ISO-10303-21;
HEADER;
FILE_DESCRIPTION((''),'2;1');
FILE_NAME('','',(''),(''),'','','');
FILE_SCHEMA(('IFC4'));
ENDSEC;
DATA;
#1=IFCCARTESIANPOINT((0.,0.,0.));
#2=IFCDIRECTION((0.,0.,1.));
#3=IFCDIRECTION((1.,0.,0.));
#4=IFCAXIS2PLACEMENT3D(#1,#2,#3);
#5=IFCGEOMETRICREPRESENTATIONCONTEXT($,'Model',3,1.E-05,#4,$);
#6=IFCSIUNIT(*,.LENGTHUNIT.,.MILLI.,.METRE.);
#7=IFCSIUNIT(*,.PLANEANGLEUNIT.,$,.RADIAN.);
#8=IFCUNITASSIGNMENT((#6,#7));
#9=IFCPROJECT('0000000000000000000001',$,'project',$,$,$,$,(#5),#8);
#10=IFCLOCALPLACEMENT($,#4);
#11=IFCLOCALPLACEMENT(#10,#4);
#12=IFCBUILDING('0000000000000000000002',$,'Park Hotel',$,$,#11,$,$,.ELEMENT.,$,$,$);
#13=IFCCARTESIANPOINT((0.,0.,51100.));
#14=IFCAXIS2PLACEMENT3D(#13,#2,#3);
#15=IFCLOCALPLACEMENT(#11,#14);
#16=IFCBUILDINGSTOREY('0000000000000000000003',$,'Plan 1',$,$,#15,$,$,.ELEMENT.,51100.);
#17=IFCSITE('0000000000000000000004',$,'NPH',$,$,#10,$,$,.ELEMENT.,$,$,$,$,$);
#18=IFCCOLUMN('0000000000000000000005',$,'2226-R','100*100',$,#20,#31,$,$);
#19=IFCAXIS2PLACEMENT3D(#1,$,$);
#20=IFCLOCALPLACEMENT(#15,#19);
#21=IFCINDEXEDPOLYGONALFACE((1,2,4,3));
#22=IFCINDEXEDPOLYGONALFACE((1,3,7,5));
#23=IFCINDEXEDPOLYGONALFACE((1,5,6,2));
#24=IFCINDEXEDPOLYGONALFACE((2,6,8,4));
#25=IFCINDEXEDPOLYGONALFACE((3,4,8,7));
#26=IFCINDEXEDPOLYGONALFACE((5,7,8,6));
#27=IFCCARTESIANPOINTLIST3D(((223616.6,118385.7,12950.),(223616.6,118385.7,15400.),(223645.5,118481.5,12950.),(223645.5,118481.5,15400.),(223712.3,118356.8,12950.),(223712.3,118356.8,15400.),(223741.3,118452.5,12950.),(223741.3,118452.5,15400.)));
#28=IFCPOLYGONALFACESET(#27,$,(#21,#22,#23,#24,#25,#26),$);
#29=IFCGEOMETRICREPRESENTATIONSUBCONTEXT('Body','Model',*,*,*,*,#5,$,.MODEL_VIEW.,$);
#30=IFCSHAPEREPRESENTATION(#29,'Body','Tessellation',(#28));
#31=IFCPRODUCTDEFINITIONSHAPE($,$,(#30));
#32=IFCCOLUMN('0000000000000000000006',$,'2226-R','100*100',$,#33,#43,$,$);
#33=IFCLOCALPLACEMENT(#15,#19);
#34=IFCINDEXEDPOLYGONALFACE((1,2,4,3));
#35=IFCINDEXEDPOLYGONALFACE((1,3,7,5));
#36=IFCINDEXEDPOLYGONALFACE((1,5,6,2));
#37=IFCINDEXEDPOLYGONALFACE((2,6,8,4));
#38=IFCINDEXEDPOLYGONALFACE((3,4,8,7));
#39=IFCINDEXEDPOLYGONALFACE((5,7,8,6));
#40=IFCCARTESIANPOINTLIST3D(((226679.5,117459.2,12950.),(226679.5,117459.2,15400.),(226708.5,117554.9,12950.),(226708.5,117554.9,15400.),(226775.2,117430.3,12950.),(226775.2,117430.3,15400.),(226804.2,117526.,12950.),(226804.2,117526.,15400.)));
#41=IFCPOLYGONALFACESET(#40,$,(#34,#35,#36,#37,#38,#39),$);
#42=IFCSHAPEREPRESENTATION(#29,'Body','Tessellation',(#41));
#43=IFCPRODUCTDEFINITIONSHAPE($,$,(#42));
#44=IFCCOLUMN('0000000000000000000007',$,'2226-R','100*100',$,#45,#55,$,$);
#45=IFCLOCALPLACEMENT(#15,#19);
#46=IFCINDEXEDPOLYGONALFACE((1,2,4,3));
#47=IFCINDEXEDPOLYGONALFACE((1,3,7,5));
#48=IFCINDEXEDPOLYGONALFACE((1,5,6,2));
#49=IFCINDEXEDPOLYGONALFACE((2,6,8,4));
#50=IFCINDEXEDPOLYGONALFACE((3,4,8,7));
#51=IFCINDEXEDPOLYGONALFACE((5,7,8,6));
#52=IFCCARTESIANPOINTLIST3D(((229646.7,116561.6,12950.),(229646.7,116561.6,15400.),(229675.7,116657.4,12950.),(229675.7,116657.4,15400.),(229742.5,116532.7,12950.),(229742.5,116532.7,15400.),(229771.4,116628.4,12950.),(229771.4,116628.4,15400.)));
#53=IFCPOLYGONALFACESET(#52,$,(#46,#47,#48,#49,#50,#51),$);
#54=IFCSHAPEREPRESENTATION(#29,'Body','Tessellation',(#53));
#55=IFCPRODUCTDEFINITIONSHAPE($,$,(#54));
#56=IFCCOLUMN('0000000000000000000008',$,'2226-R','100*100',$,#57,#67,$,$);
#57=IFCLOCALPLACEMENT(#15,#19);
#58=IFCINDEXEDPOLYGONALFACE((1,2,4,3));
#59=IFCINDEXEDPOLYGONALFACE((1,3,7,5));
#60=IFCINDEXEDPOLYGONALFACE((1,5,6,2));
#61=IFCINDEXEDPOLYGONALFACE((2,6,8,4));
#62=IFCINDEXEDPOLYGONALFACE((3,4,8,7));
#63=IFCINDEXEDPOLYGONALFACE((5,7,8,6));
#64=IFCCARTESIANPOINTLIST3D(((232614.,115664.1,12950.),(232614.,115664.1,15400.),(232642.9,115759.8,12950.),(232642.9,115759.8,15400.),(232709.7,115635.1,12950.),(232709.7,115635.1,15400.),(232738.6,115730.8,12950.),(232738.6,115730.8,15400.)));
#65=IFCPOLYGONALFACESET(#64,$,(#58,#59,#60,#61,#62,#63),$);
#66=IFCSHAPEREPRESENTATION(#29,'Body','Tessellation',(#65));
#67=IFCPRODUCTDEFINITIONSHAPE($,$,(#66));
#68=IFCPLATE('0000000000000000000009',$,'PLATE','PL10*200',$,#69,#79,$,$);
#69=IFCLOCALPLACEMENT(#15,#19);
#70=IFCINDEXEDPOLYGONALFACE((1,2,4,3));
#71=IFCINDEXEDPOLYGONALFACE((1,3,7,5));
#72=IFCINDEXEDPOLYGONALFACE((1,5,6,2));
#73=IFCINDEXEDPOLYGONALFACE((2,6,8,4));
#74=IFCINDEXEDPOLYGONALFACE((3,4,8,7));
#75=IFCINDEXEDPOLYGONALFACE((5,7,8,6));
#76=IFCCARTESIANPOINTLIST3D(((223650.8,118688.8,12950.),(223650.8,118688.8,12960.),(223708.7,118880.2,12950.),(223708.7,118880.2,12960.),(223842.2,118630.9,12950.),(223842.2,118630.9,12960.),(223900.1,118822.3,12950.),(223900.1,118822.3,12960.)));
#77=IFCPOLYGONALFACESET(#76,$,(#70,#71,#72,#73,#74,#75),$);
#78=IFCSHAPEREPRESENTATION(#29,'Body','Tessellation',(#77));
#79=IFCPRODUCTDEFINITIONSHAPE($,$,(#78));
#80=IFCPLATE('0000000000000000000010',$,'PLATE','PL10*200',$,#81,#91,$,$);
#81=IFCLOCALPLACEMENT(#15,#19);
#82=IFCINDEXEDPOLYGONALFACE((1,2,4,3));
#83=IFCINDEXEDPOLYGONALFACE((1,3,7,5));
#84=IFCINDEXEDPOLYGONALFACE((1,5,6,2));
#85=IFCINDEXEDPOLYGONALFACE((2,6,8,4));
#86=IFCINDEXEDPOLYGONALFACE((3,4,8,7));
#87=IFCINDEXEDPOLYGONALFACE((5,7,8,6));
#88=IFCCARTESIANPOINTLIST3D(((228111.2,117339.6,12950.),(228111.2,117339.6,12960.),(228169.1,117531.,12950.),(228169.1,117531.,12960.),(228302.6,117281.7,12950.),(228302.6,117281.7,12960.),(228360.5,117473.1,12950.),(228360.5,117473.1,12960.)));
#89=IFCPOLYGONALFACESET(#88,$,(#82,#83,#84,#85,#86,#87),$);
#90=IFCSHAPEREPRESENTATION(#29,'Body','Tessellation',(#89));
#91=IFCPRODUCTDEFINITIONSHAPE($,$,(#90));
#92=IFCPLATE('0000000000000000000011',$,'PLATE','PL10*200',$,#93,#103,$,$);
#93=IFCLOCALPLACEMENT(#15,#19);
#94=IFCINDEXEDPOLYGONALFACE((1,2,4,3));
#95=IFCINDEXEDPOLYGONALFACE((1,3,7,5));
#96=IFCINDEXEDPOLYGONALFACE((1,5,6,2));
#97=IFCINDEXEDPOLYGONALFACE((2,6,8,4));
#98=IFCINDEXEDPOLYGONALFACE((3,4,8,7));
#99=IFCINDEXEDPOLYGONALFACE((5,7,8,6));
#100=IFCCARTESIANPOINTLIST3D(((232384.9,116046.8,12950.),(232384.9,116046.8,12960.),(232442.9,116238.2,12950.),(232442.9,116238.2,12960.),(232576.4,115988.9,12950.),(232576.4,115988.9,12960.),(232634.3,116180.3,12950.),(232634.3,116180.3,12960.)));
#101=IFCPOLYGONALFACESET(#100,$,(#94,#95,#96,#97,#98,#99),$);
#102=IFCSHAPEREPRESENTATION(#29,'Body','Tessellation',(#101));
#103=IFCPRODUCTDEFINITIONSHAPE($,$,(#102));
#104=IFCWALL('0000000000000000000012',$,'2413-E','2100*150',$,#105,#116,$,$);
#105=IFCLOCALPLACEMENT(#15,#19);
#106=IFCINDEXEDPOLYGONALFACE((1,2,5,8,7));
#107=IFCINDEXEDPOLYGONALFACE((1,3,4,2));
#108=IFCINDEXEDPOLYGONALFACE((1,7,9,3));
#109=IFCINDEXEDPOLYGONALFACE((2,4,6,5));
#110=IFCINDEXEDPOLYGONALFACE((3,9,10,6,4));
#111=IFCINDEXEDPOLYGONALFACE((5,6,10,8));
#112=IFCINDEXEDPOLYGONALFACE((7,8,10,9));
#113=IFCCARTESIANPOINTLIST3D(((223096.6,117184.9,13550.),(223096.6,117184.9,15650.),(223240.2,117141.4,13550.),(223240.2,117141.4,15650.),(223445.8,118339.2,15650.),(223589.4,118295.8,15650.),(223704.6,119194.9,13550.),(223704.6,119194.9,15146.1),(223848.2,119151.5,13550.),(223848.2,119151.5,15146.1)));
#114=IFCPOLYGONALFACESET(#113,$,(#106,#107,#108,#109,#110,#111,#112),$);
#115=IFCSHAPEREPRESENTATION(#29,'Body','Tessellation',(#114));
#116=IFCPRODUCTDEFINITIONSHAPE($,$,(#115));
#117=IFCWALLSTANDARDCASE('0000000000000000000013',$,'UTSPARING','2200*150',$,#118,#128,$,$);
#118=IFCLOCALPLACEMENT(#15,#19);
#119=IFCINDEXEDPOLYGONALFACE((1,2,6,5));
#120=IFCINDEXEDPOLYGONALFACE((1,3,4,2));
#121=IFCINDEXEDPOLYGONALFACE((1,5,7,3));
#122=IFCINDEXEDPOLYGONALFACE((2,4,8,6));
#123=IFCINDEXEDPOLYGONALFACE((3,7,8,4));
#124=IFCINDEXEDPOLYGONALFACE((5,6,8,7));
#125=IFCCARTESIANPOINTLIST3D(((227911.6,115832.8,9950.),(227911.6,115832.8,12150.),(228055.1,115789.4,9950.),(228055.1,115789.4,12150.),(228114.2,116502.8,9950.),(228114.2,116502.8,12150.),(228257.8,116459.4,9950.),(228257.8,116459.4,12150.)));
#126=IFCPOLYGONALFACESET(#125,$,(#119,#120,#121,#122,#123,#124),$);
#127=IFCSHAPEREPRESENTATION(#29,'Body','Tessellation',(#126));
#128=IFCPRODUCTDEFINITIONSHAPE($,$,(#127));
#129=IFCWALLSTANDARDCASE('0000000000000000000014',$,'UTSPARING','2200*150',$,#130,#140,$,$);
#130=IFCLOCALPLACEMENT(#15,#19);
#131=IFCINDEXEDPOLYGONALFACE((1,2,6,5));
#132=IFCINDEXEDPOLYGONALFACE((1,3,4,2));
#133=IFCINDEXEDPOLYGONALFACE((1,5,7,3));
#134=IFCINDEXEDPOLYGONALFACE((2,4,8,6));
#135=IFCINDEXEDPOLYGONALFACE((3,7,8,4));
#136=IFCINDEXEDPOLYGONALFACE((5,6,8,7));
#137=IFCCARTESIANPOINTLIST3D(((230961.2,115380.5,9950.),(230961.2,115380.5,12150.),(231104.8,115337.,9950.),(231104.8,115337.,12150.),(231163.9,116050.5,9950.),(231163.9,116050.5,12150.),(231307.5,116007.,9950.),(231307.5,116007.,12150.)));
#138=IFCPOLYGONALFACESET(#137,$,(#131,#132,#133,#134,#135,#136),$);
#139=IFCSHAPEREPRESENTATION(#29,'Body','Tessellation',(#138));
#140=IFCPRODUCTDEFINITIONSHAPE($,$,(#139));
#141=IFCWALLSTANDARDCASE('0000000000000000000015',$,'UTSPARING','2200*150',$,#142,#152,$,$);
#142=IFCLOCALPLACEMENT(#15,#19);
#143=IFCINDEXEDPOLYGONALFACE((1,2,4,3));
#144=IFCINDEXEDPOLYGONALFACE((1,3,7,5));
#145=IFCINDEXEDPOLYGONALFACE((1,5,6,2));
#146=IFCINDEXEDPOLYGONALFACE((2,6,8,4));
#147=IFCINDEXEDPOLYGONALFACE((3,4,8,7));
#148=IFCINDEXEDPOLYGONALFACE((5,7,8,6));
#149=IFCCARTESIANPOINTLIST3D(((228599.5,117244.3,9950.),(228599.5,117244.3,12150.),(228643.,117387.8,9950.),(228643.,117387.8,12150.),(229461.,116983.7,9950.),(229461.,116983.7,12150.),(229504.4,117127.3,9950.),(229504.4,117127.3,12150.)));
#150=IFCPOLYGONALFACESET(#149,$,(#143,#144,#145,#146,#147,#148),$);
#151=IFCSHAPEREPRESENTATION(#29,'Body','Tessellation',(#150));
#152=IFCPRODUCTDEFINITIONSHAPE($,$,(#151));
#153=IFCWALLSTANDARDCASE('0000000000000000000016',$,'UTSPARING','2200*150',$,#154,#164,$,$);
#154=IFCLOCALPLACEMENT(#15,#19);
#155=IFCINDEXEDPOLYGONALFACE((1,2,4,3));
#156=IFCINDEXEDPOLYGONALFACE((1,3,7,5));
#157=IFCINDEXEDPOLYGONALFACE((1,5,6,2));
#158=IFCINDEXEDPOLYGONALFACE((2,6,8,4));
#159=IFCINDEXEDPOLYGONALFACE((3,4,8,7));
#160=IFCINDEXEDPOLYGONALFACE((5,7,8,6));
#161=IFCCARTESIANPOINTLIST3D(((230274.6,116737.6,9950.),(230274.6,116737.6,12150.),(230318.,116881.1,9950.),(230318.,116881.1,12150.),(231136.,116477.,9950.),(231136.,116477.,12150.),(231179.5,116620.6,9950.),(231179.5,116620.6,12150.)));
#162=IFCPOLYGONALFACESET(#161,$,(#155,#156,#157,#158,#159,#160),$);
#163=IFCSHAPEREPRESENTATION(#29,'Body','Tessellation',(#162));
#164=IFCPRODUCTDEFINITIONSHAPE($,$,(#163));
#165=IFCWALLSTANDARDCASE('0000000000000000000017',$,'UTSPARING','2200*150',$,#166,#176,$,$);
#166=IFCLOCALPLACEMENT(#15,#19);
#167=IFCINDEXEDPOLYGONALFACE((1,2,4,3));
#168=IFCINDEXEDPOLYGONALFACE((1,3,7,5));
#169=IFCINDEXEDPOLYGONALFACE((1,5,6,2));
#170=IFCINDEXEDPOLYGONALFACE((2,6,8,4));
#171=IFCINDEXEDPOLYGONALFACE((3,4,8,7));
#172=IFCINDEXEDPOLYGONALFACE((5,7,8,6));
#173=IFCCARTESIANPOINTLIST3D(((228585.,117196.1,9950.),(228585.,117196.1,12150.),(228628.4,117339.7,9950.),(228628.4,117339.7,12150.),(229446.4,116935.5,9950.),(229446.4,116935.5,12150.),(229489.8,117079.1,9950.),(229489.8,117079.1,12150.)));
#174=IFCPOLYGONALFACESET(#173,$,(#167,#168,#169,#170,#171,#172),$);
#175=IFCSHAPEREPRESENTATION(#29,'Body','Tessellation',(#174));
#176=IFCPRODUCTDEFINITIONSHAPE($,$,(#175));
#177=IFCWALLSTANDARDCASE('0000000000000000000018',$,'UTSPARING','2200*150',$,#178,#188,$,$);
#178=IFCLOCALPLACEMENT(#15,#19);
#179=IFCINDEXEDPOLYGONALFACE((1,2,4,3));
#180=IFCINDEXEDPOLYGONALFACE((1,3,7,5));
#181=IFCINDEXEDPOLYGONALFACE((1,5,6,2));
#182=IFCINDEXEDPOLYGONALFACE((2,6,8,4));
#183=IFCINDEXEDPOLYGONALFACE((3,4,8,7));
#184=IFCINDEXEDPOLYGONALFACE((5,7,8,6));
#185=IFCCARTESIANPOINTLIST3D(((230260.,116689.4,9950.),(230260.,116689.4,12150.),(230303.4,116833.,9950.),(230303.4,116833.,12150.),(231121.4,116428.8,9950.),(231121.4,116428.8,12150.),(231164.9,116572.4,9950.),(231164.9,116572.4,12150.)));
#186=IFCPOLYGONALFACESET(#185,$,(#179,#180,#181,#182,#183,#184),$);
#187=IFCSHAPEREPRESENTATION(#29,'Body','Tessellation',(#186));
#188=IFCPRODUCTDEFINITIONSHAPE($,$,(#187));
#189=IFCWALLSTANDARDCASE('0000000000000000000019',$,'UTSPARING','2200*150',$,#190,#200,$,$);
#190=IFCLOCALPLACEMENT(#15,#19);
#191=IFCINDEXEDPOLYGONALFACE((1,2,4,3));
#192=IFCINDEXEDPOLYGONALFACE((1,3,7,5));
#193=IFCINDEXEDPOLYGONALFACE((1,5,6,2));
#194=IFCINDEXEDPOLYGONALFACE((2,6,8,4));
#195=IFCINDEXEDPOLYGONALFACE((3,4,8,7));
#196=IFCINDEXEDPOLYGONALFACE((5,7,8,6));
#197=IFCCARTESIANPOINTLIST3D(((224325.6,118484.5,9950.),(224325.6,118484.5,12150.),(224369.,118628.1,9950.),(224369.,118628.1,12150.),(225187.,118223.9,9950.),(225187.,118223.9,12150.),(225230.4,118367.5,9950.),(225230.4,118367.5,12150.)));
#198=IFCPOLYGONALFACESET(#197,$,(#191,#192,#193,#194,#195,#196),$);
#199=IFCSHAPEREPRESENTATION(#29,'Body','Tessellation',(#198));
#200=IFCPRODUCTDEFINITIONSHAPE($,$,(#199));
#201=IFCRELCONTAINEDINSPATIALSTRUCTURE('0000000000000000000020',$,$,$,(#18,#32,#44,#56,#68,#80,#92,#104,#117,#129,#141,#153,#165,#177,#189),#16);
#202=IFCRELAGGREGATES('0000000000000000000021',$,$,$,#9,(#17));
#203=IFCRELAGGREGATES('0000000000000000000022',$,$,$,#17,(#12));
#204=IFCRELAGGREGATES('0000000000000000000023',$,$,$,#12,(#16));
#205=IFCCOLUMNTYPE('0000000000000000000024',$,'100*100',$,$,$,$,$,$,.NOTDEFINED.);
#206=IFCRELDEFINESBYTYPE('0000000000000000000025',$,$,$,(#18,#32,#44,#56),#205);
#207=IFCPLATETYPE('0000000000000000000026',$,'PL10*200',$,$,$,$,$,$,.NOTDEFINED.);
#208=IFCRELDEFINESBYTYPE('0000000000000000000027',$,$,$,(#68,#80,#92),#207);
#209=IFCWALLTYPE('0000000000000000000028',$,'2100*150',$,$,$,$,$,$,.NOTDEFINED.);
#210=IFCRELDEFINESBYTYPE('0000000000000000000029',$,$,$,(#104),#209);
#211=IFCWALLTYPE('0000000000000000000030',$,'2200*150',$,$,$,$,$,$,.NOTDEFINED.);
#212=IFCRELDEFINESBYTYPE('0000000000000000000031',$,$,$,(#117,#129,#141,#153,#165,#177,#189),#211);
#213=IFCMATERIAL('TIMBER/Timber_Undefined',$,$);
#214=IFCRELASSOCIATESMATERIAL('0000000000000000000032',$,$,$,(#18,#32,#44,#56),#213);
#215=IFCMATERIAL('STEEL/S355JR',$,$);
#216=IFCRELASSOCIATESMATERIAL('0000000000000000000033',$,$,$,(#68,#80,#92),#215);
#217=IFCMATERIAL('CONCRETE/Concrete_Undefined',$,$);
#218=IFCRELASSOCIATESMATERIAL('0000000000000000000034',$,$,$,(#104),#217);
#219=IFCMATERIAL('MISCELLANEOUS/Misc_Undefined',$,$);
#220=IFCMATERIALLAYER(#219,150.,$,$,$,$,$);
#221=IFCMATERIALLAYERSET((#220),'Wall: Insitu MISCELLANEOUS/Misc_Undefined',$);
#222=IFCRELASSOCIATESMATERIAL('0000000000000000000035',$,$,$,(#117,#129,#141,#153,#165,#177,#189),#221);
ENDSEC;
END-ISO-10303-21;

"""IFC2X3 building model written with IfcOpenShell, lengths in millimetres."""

from ifc_helpers import new_model, si_unit, frame, frame_2d, origin_with_axes, origin_2d_with_axis, place, context, subcontext, project, spatial, polyline, rectangle, outline, extrude, clip, halfspace, material, layer, layer_set, layer_usage, type_object, element, save


model = new_model("IFC2X3")

# Units and contexts
model_context = context("Model", 3, precision=1e-05, world=origin_with_axes())
body_context = subcontext(model_context, "Body", "Model", "MODEL_VIEW")
ifc_project = project(units=[si_unit("LENGTHUNIT", "METRE", prefix="MILLI"), si_unit("PLANEANGLEUNIT", "RADIAN")], contexts=[model_context])

# Site, building, storey
site_placement = place(None, origin_with_axes())
site = spatial("IfcSite", under=ifc_project, at=site_placement, Name="NPH", CompositionType="ELEMENT")
building_placement = place(site_placement, origin_with_axes())
building = spatial("IfcBuilding", under=site, at=building_placement, Name="Park Hotel", CompositionType="ELEMENT")
storey_placement = place(building_placement, frame((0.0, 0.0, 51100.0), z_axis=(0.0, 0.0, 1.0), x_axis=(1.0, 0.0, 0.0)))
storey = spatial("IfcBuildingStorey", under=building, at=storey_placement, Name="Plan 1", CompositionType="ELEMENT", Elevation=51100.0)

# Columns
ifc_material_1 = material(Name="TIMBER/Timber_Undefined")
column_type = type_object("IfcColumnType", Name="100*100", PredefinedType="NOTDEFINED")
for number, where, z_axis, x_axis, name in (
    (1, (223678.9, 118419.1, 15400.0), (0.0, 0.0, -1.0), (0.289538, 0.957167, 0.0), "2226-R"),
    (2, (226741.9, 117492.6, 15400.0), (0.0, 0.0, -1.0), (0.289538, 0.957167, 0.0), "2226-R"),
    (3, (229709.1, 116595.0, 15400.0), (0.0, 0.0, -1.0), (0.289538, 0.957167, 0.0), "2226-R"),
    (4, (232676.3, 115697.5, 15400.0), (0.0, 0.0, -1.0), (0.289538, 0.957167, 0.0), "2226-R"),
):
    element("IfcColumn", number, at=place(storey_placement, frame(where, z_axis=z_axis, x_axis=x_axis)), inside=storey, type_object=column_type, material=ifc_material_1, Name=name, Description="100*100", context=body_context, shape_type="SweptSolid", body=[
        extrude(rectangle(XDim=100.0, YDim=100.0, at=origin_2d_with_axis()), frame((0.0, 0.0, 2450.0), z_axis=(0.0, 0.0, -1.0), x_axis=(0.0, 1.0, 0.0)), (0.0, 0.0, 1.0), 2450.0),
    ])

# Plates
ifc_material_2 = material(Name="STEEL/S355JR")
plate_type = type_object("IfcPlateType", Name="PL10*200", PredefinedType="NOTDEFINED")
for number, where, z_axis, x_axis, name in (
    (5, (223871.2, 118726.6, 12955.0), (0.0, 0.0, 1.0), (-0.957167, 0.289538, 0.0), "PLATE"),
    (6, (228331.6, 117377.4, 12955.0), (0.0, 0.0, 1.0), (-0.957167, 0.289538, 0.0), "PLATE"),
    (7, (232605.3, 116084.6, 12955.0), (0.0, 0.0, 1.0), (-0.957167, 0.289538, 0.0), "PLATE"),
):
    element("IfcPlate", number, at=place(storey_placement, frame(where, z_axis=z_axis, x_axis=x_axis)), inside=storey, type_object=plate_type, material=ifc_material_2, Name=name, Description="PL10*200", context=body_context, shape_type="SweptSolid", body=[
        extrude(outline(polyline([(200.0, 100.0), (200.0, -100.0), (0.0, -100.0), (0.0, 100.0), (200.0, 100.0)])), frame((0.0, 0.0, -5.0), z_axis=(0.0, 0.0, 1.0), x_axis=(1.0, 0.0, 0.0)), (0.0, 0.0, 1.0), 10.0),
    ])

# Walls
ifc_material_3 = material(Name="CONCRETE/Concrete_Undefined")
wall_type_1 = type_object("IfcWallType", Name="2100*150", PredefinedType="NOTDEFINED")
wall_1_placement = place(storey_placement, frame((223776.4, 119173.2, 13550.0), z_axis=(0.0, 0.0, 1.0), x_axis=(-0.289536, -0.957167, 0.0)))
element("IfcWall", 8, at=wall_1_placement, inside=storey, type_object=wall_type_1, material=ifc_material_3, Name="2413-E", Description="2100*150", context=body_context, shape_type="Clipping", body=[
    clip(extrude(rectangle(XDim=2100.0, YDim=150.0, at=frame_2d((0.0, 1050.0), x_axis=(0.0, -1.0))), frame((0.0, 0.0, 0.0), z_axis=(0.0, 0.0, 1.0), x_axis=(0.0, -1.0, 0.0)), (0.0, 0.0, 1.0), 2100.0), halfspace(frame((-3896.1, 75.0, -599.9), z_axis=(-0.491013, 0.000001, 0.871152), x_axis=(0.871152, -0.000002, 0.491013)), False)),
])
ifc_material_4 = material(Name="MISCELLANEOUS/Misc_Undefined")
ifc_layer_1 = layer(ifc_material_4, 150.0)
ifc_layer_set_1 = layer_set([ifc_layer_1], Name="Wall: Insitu MISCELLANEOUS/Misc_Undefined")
ifc_layer_usage_1 = layer_usage(ifc_layer_set_1, "AXIS2", "POSITIVE", -75.0)
wall_type_2 = type_object("IfcWallType", Name="2200*150", PredefinedType="NOTDEFINED")
wall_2_placement = place(storey_placement, frame((228186.0, 116481.1, 9950.0), z_axis=(0.0, 0.0, 1.0), x_axis=(-0.289534, -0.957168, 0.0)))
element("IfcWallStandardCase", 9, at=wall_2_placement, inside=storey, type_object=wall_type_2, material=ifc_layer_usage_1, Name="UTSPARING", Description="2200*150", context=body_context, shape_type="SweptSolid", body=[
    extrude(rectangle(XDim=700.0, YDim=150.0, at=frame_2d((0.0, 350.0), x_axis=(0.0, -1.0))), frame((0.0, 0.0, 0.0), z_axis=(0.0, 0.0, 1.0), x_axis=(0.0, -1.0, 0.0)), (0.0, 0.0, 1.0), 2200.0),
])
ifc_layer_usage_2 = layer_usage(ifc_layer_set_1, "AXIS2", "POSITIVE", -75.0)
wall_3_placement = place(storey_placement, frame((231235.7, 116028.8, 9950.0), z_axis=(0.0, 0.0, 1.0), x_axis=(-0.289534, -0.957168, 0.0)))
element("IfcWallStandardCase", 10, at=wall_3_placement, inside=storey, type_object=wall_type_2, material=ifc_layer_usage_2, Name="UTSPARING", Description="2200*150", context=body_context, shape_type="SweptSolid", body=[
    extrude(rectangle(XDim=700.0, YDim=150.0, at=frame_2d((0.0, 350.0), x_axis=(0.0, -1.0))), frame((0.0, 0.0, 0.0), z_axis=(0.0, 0.0, 1.0), x_axis=(0.0, -1.0, 0.0)), (0.0, 0.0, 1.0), 2200.0),
])
ifc_layer_usage_3 = layer_usage(ifc_layer_set_1, "AXIS2", "POSITIVE", -75.0)
wall_4_placement = place(storey_placement, frame((228621.2, 117316.0, 9950.0), z_axis=(0.0, 0.0, 1.0), x_axis=(0.957168, -0.289534, 0.0)))
element("IfcWallStandardCase", 11, at=wall_4_placement, inside=storey, type_object=wall_type_2, material=ifc_layer_usage_3, Name="UTSPARING", Description="2200*150", context=body_context, shape_type="SweptSolid", body=[
    extrude(rectangle(XDim=900.0, YDim=150.0, at=frame_2d((0.0, 450.0), x_axis=(0.0, -1.0))), frame((0.0, 0.0, 0.0), z_axis=(0.0, 0.0, 1.0), x_axis=(0.0, -1.0, 0.0)), (0.0, 0.0, 1.0), 2200.0),
])
ifc_layer_usage_4 = layer_usage(ifc_layer_set_1, "AXIS2", "POSITIVE", -75.0)
wall_5_placement = place(storey_placement, frame((230296.3, 116809.4, 9950.0), z_axis=(0.0, 0.0, 1.0), x_axis=(0.957168, -0.289534, 0.0)))
element("IfcWallStandardCase", 12, at=wall_5_placement, inside=storey, type_object=wall_type_2, material=ifc_layer_usage_4, Name="UTSPARING", Description="2200*150", context=body_context, shape_type="SweptSolid", body=[
    extrude(rectangle(XDim=900.0, YDim=150.0, at=frame_2d((0.0, 450.0), x_axis=(0.0, -1.0))), frame((0.0, 0.0, 0.0), z_axis=(0.0, 0.0, 1.0), x_axis=(0.0, -1.0, 0.0)), (0.0, 0.0, 1.0), 2200.0),
])
ifc_layer_usage_5 = layer_usage(ifc_layer_set_1, "AXIS2", "POSITIVE", -75.0)
wall_6_placement = place(storey_placement, frame((228606.7, 117267.9, 9950.0), z_axis=(0.0, 0.0, 1.0), x_axis=(0.957166, -0.289541, 0.0)))
element("IfcWallStandardCase", 13, at=wall_6_placement, inside=storey, type_object=wall_type_2, material=ifc_layer_usage_5, Name="UTSPARING", Description="2200*150", context=body_context, shape_type="SweptSolid", body=[
    extrude(rectangle(XDim=900.0, YDim=150.0, at=frame_2d((0.0, 450.0), x_axis=(0.0, -1.0))), frame((0.0, 0.0, 0.0), z_axis=(0.0, 0.0, 1.0), x_axis=(0.0, -1.0, 0.0)), (0.0, 0.0, 1.0), 2200.0),
])
ifc_layer_usage_6 = layer_usage(ifc_layer_set_1, "AXIS2", "POSITIVE", -75.0)
wall_7_placement = place(storey_placement, frame((230281.7, 116761.2, 9950.0), z_axis=(0.0, 0.0, 1.0), x_axis=(0.957166, -0.289541, 0.0)))
element("IfcWallStandardCase", 14, at=wall_7_placement, inside=storey, type_object=wall_type_2, material=ifc_layer_usage_6, Name="UTSPARING", Description="2200*150", context=body_context, shape_type="SweptSolid", body=[
    extrude(rectangle(XDim=900.0, YDim=150.0, at=frame_2d((0.0, 450.0), x_axis=(0.0, -1.0))), frame((0.0, 0.0, 0.0), z_axis=(0.0, 0.0, 1.0), x_axis=(0.0, -1.0, 0.0)), (0.0, 0.0, 1.0), 2200.0),
])
ifc_layer_usage_7 = layer_usage(ifc_layer_set_1, "AXIS2", "POSITIVE", -75.0)
wall_8_placement = place(storey_placement, frame((224347.3, 118556.3, 9950.0), z_axis=(0.0, 0.0, 1.0), x_axis=(0.957166, -0.289541, 0.0)))
element("IfcWallStandardCase", 15, at=wall_8_placement, inside=storey, type_object=wall_type_2, material=ifc_layer_usage_7, Name="UTSPARING", Description="2200*150", context=body_context, shape_type="SweptSolid", body=[
    extrude(rectangle(XDim=900.0, YDim=150.0, at=frame_2d((0.0, 450.0), x_axis=(0.0, -1.0))), frame((0.0, 0.0, 0.0), z_axis=(0.0, 0.0, 1.0), x_axis=(0.0, -1.0, 0.0)), (0.0, 0.0, 1.0), 2200.0),
])

save(model, "model.ifc")
